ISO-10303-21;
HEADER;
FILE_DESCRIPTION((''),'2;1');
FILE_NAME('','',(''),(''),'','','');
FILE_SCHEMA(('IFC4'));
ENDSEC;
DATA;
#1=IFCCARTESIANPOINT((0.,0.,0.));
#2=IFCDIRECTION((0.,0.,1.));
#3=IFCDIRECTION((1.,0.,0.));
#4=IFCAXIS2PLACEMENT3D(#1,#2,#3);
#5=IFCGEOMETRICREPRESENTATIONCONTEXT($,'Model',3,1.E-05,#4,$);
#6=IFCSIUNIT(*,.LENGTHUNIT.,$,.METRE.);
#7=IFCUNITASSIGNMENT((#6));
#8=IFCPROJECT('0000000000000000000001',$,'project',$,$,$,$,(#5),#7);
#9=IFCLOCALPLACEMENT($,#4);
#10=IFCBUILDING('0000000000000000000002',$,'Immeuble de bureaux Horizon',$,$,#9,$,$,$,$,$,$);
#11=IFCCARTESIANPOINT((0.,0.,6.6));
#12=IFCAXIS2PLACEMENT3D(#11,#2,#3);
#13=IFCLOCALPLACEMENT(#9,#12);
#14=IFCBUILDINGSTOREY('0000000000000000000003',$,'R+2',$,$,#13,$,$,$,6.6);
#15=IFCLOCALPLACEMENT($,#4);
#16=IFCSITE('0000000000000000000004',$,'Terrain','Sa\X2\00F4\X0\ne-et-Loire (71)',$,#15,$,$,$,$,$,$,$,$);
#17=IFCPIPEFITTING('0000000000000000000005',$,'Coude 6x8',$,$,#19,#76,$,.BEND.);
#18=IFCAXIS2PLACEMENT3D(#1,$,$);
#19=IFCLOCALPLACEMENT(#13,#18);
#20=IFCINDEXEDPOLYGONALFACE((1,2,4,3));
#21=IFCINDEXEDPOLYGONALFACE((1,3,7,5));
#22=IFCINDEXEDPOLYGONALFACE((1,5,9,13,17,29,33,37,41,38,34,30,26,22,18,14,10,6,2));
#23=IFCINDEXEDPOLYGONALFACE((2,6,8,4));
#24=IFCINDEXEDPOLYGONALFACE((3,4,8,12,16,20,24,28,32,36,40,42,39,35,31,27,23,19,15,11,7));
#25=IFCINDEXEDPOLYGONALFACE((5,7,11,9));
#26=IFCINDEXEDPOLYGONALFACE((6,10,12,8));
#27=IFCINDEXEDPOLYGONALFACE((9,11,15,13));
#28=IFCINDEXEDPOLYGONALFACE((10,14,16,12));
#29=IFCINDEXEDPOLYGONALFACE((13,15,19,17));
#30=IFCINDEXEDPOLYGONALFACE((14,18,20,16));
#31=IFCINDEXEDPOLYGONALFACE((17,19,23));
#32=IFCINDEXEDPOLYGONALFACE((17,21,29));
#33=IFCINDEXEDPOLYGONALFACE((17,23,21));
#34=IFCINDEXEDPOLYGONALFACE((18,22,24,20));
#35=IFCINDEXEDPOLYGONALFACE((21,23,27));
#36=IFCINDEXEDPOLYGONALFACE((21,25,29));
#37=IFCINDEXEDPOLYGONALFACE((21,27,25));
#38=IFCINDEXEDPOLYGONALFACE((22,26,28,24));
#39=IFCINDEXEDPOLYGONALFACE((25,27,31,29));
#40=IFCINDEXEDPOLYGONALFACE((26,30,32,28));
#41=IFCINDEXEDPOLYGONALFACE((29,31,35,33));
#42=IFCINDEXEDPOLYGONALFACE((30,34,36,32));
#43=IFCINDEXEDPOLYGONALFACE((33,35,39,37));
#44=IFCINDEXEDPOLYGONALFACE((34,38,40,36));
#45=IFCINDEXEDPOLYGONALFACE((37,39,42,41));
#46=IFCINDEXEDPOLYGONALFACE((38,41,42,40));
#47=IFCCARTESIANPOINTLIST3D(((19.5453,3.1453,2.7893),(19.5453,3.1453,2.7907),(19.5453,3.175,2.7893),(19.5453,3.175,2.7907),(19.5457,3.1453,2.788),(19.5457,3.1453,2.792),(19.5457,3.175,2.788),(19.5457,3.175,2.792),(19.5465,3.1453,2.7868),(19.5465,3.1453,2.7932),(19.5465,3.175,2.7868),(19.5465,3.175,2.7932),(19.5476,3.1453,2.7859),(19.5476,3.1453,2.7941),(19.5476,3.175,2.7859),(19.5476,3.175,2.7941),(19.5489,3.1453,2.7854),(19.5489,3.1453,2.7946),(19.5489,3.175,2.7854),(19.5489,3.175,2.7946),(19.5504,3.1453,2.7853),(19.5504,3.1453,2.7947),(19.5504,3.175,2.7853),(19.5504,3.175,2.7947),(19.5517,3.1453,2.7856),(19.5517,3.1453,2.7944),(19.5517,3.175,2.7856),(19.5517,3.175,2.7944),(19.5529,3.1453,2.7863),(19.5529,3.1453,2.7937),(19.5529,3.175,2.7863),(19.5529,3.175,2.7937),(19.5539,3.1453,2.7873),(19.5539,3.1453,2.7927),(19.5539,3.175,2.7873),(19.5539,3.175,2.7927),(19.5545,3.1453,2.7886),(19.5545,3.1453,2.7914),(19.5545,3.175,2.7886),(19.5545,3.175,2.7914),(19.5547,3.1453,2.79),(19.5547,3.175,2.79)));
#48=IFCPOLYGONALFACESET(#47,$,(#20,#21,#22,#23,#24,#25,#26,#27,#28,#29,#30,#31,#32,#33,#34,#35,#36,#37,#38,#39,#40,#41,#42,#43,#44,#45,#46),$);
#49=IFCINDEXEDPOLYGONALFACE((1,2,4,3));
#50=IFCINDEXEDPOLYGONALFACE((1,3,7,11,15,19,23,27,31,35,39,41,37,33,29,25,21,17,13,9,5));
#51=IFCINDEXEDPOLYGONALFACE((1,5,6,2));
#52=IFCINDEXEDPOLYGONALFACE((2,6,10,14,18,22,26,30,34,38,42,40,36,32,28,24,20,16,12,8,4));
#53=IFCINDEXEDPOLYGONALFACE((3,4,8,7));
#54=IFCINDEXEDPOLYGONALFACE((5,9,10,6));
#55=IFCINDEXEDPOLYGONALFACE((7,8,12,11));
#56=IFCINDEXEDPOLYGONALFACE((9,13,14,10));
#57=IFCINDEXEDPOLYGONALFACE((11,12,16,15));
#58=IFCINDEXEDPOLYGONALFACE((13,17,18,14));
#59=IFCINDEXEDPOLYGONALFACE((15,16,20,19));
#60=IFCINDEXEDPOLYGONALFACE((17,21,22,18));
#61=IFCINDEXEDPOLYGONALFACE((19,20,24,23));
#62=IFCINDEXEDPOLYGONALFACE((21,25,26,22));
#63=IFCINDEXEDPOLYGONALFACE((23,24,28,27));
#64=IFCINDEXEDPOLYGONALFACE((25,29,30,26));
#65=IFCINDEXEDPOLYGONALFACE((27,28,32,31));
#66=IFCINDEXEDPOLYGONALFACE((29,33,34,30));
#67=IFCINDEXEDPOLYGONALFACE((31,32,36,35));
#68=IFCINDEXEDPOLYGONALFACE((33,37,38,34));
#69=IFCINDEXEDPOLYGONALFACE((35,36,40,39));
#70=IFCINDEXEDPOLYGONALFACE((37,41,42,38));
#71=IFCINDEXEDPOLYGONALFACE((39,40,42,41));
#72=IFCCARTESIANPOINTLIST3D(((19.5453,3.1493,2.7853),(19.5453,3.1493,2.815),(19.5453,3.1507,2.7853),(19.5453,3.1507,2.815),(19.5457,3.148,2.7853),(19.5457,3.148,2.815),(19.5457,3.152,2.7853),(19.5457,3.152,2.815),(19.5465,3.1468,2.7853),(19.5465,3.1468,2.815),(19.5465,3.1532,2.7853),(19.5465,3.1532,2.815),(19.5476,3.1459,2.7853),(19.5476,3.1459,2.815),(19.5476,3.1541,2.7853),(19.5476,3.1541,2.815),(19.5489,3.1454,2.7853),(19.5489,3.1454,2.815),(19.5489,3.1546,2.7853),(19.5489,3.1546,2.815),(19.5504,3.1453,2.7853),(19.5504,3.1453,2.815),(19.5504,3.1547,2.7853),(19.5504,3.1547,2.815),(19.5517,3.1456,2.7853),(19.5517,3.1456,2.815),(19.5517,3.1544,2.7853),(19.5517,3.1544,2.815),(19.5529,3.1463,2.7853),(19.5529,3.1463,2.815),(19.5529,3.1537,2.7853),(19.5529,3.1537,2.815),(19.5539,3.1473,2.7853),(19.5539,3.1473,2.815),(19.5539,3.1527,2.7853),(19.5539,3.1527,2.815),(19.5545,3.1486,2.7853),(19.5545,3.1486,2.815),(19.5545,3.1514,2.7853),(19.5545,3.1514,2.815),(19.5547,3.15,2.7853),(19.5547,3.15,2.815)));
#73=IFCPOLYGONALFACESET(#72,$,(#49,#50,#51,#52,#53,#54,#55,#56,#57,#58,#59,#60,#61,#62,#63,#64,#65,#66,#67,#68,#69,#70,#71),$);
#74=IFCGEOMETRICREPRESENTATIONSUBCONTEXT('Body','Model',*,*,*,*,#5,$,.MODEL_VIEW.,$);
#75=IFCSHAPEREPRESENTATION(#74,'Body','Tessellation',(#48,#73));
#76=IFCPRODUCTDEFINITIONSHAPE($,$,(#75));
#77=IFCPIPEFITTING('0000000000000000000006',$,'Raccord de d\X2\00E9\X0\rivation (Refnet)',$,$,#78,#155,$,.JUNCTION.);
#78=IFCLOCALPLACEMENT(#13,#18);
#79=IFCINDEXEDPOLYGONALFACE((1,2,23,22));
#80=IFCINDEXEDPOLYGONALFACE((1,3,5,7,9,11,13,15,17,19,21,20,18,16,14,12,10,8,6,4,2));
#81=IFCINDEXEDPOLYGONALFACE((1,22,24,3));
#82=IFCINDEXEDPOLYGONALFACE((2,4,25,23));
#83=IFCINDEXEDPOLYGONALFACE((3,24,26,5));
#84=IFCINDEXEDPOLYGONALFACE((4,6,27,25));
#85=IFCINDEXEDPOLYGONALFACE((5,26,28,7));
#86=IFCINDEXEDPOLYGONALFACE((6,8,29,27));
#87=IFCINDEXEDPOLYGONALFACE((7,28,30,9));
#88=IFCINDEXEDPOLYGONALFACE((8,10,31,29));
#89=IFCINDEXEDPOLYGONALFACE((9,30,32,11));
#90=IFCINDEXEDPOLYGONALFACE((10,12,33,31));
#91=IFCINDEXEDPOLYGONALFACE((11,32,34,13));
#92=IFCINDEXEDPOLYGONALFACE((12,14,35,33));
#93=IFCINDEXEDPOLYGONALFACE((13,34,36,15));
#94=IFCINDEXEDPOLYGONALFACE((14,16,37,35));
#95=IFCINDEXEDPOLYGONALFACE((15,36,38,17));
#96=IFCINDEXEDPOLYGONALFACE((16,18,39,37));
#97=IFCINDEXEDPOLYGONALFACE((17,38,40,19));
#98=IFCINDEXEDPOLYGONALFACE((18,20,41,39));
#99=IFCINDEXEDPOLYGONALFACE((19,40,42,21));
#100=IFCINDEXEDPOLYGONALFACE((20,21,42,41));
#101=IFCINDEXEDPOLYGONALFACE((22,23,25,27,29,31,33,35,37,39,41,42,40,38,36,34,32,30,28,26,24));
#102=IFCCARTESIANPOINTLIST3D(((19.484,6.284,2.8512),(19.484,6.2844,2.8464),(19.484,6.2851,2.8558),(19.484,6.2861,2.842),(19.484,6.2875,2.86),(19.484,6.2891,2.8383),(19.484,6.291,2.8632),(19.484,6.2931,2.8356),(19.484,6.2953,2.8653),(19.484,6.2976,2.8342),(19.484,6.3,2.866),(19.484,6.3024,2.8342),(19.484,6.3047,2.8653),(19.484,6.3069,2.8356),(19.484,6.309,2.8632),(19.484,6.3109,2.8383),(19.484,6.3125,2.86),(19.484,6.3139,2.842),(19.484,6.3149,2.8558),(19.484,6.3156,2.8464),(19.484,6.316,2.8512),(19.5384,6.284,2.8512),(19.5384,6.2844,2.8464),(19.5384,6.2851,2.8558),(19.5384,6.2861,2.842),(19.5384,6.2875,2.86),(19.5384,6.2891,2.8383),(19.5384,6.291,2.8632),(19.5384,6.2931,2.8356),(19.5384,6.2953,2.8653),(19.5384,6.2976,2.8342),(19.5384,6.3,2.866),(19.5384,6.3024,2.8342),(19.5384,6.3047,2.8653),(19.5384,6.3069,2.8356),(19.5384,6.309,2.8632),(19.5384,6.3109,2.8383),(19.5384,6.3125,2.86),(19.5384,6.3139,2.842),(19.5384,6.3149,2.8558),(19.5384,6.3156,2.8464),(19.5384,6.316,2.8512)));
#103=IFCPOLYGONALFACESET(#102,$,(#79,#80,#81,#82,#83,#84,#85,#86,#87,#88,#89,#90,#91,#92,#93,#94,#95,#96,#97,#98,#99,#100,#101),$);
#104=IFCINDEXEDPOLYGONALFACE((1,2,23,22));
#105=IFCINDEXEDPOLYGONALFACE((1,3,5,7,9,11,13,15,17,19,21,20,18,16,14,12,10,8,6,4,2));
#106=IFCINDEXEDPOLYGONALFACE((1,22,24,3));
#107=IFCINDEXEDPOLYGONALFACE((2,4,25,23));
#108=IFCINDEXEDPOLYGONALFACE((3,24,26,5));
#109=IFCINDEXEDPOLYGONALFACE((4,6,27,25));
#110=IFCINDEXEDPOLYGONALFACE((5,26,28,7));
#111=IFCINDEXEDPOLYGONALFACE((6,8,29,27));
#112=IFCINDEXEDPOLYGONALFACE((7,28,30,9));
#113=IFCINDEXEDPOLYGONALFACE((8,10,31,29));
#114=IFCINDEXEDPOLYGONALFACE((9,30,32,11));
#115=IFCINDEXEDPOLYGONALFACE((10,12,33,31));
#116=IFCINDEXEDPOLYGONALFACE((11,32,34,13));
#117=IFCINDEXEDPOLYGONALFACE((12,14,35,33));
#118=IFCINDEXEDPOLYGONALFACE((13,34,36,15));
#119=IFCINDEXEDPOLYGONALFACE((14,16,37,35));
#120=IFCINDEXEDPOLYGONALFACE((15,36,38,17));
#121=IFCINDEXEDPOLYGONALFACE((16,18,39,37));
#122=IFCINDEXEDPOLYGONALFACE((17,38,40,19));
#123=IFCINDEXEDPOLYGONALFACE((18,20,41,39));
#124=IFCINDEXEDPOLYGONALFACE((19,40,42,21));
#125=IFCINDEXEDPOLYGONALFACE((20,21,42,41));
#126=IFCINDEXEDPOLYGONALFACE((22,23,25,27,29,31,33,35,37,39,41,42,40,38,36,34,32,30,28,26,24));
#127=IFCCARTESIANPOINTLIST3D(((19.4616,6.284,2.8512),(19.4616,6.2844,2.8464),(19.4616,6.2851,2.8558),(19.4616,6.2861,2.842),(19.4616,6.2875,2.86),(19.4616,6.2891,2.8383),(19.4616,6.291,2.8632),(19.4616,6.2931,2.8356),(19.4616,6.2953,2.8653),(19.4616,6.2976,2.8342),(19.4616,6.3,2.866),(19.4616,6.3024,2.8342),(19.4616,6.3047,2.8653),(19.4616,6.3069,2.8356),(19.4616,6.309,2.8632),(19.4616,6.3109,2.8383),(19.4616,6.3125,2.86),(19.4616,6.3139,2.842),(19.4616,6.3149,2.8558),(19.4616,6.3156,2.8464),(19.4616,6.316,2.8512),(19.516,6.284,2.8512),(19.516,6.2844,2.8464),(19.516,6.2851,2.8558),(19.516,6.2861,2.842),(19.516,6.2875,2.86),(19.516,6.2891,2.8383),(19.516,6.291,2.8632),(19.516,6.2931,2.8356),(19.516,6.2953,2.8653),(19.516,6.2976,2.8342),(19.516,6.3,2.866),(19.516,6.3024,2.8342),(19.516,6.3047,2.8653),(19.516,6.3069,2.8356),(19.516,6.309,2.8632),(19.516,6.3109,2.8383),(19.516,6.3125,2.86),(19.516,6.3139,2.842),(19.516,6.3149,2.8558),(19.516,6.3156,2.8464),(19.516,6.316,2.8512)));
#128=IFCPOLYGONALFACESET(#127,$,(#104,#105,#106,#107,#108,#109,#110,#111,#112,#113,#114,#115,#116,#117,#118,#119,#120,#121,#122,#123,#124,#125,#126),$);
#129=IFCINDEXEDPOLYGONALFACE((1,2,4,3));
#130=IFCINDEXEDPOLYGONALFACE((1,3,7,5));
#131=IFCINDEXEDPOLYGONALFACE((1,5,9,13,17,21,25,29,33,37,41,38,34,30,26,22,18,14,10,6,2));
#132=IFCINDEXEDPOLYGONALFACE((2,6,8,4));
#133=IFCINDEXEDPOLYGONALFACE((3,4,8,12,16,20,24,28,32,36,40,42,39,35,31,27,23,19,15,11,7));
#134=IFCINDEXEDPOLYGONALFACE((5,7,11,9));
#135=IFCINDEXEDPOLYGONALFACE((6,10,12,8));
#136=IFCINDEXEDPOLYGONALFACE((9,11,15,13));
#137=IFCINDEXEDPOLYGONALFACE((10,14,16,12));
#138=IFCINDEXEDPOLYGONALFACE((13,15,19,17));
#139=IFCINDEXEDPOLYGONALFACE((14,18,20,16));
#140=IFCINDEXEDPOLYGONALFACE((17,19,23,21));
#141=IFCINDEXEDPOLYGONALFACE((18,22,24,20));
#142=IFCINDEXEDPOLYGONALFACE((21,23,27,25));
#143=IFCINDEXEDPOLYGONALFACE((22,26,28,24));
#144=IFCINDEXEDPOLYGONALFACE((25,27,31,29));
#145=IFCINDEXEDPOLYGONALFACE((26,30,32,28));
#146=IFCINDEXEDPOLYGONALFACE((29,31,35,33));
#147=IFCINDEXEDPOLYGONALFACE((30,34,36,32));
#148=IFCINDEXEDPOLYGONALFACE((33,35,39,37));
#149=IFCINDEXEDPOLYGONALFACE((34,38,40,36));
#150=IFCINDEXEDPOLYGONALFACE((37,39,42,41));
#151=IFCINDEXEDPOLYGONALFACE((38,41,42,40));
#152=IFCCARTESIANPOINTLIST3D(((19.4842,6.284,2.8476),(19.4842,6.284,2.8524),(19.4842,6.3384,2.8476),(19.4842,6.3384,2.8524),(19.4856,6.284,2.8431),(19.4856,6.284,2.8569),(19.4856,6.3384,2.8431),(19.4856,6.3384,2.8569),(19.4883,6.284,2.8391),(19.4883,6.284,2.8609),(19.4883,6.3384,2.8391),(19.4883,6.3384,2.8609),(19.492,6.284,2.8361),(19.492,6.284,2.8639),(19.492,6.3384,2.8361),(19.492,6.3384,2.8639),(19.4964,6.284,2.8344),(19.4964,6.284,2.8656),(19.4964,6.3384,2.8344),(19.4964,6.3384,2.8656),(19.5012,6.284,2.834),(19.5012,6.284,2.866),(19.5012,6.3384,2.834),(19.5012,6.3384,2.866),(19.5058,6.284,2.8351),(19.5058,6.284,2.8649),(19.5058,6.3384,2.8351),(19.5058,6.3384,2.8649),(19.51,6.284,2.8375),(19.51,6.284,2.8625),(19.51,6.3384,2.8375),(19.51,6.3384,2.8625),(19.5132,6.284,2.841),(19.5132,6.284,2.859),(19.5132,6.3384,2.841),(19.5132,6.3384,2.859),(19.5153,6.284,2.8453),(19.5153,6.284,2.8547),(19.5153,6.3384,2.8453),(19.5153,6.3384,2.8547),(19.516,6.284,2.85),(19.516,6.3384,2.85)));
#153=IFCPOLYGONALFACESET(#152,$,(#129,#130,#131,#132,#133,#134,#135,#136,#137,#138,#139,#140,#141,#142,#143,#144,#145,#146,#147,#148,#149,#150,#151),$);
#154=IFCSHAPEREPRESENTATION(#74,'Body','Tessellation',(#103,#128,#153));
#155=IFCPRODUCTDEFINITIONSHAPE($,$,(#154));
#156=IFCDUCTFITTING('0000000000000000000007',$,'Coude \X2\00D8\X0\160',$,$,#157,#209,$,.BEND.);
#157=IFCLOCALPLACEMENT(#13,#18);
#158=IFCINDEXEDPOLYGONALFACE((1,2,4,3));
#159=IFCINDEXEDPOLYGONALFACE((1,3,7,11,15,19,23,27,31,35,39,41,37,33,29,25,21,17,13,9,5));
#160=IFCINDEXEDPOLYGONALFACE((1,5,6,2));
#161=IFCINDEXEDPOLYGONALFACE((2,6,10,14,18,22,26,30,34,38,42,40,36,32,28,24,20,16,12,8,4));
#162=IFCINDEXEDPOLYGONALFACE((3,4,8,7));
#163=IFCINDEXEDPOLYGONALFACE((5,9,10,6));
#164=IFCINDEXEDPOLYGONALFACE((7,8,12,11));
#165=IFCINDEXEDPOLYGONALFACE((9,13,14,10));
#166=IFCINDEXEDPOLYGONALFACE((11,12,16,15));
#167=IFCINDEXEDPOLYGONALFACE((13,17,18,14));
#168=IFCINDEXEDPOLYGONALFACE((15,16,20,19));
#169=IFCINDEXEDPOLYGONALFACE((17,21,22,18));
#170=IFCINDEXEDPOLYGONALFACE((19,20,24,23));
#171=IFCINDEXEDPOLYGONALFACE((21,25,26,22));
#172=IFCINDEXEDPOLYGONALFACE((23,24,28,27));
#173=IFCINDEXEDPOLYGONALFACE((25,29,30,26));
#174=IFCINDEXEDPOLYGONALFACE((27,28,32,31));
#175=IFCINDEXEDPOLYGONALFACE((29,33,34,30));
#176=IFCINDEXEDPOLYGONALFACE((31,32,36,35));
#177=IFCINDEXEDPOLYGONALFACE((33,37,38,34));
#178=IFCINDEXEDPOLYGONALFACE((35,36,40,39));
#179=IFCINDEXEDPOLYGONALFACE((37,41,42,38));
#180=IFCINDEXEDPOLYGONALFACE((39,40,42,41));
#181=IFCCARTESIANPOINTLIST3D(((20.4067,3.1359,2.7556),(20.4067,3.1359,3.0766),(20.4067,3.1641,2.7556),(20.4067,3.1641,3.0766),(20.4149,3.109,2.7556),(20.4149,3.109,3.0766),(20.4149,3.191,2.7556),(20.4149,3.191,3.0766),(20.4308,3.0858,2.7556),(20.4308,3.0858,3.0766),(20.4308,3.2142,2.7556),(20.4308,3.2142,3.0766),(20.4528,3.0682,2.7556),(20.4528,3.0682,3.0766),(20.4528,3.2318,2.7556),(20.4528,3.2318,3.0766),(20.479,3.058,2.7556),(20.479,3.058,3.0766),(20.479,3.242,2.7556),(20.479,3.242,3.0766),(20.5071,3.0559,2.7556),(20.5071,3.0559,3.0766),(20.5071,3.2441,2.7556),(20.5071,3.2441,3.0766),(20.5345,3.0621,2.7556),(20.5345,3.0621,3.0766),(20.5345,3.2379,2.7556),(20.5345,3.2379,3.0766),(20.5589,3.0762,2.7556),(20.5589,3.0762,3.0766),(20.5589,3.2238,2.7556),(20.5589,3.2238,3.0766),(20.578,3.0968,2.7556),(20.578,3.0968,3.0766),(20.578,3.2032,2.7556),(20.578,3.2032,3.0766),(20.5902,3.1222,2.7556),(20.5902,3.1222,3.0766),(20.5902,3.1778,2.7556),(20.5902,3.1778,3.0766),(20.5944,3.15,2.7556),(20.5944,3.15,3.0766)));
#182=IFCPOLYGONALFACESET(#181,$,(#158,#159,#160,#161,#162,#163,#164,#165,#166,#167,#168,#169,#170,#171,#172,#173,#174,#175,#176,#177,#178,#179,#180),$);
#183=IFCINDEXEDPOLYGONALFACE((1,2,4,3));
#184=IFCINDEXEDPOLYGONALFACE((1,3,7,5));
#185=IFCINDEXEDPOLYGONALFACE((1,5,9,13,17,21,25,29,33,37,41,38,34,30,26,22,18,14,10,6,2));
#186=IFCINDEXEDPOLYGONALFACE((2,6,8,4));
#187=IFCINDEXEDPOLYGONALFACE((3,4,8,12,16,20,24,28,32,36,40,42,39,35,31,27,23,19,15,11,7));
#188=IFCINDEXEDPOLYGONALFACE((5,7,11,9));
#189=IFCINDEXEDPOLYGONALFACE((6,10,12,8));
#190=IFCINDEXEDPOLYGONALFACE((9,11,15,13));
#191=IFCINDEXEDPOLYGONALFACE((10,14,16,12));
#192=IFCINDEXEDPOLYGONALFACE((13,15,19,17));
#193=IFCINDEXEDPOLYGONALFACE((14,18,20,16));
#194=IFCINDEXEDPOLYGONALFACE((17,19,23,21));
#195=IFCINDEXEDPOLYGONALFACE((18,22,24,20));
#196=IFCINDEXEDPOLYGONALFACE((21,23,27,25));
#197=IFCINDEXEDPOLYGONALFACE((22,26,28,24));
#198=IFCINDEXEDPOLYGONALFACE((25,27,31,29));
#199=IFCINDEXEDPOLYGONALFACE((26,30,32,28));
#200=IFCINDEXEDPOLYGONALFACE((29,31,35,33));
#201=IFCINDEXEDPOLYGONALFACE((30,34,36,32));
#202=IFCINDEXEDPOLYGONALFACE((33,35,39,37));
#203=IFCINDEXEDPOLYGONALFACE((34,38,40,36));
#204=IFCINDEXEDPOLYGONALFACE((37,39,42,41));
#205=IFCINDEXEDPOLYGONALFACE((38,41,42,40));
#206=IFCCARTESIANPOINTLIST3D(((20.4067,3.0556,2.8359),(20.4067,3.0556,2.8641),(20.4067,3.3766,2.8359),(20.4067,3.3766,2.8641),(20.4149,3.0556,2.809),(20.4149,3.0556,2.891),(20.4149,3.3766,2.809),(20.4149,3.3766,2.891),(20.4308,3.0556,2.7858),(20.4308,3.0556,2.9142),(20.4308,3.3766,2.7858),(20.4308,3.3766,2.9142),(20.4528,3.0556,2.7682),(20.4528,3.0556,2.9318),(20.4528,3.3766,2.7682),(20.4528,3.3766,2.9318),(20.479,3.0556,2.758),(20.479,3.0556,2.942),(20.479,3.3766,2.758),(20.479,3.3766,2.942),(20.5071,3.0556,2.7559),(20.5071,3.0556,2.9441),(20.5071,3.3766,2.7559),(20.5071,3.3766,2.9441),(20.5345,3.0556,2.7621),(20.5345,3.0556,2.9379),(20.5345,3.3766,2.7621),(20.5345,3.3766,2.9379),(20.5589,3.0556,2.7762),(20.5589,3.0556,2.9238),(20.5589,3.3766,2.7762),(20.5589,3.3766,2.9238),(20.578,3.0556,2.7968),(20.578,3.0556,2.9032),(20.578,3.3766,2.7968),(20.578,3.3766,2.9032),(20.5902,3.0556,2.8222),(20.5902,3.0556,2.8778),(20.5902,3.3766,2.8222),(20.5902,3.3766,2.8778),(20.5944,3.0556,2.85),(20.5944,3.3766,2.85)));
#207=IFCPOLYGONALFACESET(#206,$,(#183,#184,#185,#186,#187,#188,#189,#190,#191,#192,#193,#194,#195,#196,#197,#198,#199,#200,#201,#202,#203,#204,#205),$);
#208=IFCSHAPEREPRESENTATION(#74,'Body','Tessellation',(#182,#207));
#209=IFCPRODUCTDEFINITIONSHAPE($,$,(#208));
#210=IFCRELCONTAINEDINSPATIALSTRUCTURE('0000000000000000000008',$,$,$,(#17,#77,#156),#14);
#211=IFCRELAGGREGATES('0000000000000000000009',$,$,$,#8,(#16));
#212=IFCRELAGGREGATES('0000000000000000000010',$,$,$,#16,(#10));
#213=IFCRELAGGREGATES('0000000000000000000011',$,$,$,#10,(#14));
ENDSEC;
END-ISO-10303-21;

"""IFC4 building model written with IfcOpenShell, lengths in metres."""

from ifc_helpers import new_model, si_unit, frame, origin_with_axes, place, context, subcontext, project, spatial, circle, extrude, element, save


model = new_model("IFC4")

# Units and contexts
model_context = context("Model", 3, precision=1e-05, world=origin_with_axes())
body_context = subcontext(model_context, "Body", "Model", "MODEL_VIEW")
ifc_project = project(units=[si_unit("LENGTHUNIT", "METRE")], contexts=[model_context])

# Site, building, storey
site_placement = place(None, origin_with_axes())
site = spatial("IfcSite", under=ifc_project, at=site_placement, Name="Terrain", Description="Saône-et-Loire (71)")
building_placement = place(None, origin_with_axes())
building = spatial("IfcBuilding", under=site, at=building_placement, Name="Immeuble de bureaux Horizon")
storey_placement = place(building_placement, frame((0.0, 0.0, 6.6), z_axis=(0.0, 0.0, 1.0), x_axis=(1.0, 0.0, 0.0)))
storey = spatial("IfcBuildingStorey", under=building, at=storey_placement, Name="R+2", Elevation=6.6)

# Pipe fittings
pipe_fitting_1_placement = place(storey_placement, frame((19.55, 3.15, 2.79), z_axis=(0.0, 0.0, 1.0), x_axis=(1.0, 0.0, 0.0)))
element("IfcPipeFitting", 1, at=pipe_fitting_1_placement, inside=storey, Name="Coude 6x8", PredefinedType="BEND", context=body_context, shape_type="SweptSolid", body=[
    extrude(circle(Radius=0.0047), frame((0.0, -0.0047, 0.0), z_axis=(0.0, 1.0, 0.0), x_axis=(1.0, 0.0, 0.0)), (0.0, 0.0, 1.0), 0.0297),
    extrude(circle(Radius=0.0047), frame((0.0, 0.0, -0.0047), z_axis=(0.0, 0.0, 1.0), x_axis=(1.0, 0.0, 0.0)), (0.0, 0.0, 1.0), 0.0297),
])
pipe_fitting_2_placement = place(storey_placement, frame((19.5, 6.3, 2.85), z_axis=(0.0, 0.0, 1.0), x_axis=(1.0, 0.0, 0.0)))
element("IfcPipeFitting", 2, at=pipe_fitting_2_placement, inside=storey, Name="Raccord de dérivation (Refnet)", PredefinedType="JUNCTION", context=body_context, shape_type="SweptSolid", body=[
    extrude(circle(Radius=0.016), frame((-0.016, 0.0, 0.0), z_axis=(1.0, 0.0, 0.0), x_axis=(0.0, 0.0, 1.0)), (0.0, 0.0, 1.0), 0.0544),
    extrude(circle(Radius=0.016), frame((0.016, 0.0, 0.0), z_axis=(-1.0, 0.0, 0.0), x_axis=(0.0, 0.0, 1.0)), (0.0, 0.0, 1.0), 0.0544),
    extrude(circle(Radius=0.016), frame((0.0, -0.016, 0.0), z_axis=(0.0, 1.0, 0.0), x_axis=(1.0, 0.0, 0.0)), (0.0, 0.0, 1.0), 0.0544),
])

# Duct fitting
duct_fitting_1_placement = place(storey_placement, frame((20.5, 3.15, 2.85), z_axis=(0.0, 0.0, 1.0), x_axis=(1.0, 0.0, 0.0)))
element("IfcDuctFitting", 3, at=duct_fitting_1_placement, inside=storey, Name="Coude Ø160", PredefinedType="BEND", context=body_context, shape_type="SweptSolid", body=[
    extrude(circle(Radius=0.0944), frame((0.0, 0.0, -0.0944), z_axis=(0.0, 0.0, 1.0), x_axis=(1.0, 0.0, 0.0)), (0.0, 0.0, 1.0), 0.321),
    extrude(circle(Radius=0.0944), frame((0.0, -0.0944, 0.0), z_axis=(0.0, 1.0, 0.0), x_axis=(1.0, 0.0, 0.0)), (0.0, 0.0, 1.0), 0.321),
])

save(model, "model.ifc")
